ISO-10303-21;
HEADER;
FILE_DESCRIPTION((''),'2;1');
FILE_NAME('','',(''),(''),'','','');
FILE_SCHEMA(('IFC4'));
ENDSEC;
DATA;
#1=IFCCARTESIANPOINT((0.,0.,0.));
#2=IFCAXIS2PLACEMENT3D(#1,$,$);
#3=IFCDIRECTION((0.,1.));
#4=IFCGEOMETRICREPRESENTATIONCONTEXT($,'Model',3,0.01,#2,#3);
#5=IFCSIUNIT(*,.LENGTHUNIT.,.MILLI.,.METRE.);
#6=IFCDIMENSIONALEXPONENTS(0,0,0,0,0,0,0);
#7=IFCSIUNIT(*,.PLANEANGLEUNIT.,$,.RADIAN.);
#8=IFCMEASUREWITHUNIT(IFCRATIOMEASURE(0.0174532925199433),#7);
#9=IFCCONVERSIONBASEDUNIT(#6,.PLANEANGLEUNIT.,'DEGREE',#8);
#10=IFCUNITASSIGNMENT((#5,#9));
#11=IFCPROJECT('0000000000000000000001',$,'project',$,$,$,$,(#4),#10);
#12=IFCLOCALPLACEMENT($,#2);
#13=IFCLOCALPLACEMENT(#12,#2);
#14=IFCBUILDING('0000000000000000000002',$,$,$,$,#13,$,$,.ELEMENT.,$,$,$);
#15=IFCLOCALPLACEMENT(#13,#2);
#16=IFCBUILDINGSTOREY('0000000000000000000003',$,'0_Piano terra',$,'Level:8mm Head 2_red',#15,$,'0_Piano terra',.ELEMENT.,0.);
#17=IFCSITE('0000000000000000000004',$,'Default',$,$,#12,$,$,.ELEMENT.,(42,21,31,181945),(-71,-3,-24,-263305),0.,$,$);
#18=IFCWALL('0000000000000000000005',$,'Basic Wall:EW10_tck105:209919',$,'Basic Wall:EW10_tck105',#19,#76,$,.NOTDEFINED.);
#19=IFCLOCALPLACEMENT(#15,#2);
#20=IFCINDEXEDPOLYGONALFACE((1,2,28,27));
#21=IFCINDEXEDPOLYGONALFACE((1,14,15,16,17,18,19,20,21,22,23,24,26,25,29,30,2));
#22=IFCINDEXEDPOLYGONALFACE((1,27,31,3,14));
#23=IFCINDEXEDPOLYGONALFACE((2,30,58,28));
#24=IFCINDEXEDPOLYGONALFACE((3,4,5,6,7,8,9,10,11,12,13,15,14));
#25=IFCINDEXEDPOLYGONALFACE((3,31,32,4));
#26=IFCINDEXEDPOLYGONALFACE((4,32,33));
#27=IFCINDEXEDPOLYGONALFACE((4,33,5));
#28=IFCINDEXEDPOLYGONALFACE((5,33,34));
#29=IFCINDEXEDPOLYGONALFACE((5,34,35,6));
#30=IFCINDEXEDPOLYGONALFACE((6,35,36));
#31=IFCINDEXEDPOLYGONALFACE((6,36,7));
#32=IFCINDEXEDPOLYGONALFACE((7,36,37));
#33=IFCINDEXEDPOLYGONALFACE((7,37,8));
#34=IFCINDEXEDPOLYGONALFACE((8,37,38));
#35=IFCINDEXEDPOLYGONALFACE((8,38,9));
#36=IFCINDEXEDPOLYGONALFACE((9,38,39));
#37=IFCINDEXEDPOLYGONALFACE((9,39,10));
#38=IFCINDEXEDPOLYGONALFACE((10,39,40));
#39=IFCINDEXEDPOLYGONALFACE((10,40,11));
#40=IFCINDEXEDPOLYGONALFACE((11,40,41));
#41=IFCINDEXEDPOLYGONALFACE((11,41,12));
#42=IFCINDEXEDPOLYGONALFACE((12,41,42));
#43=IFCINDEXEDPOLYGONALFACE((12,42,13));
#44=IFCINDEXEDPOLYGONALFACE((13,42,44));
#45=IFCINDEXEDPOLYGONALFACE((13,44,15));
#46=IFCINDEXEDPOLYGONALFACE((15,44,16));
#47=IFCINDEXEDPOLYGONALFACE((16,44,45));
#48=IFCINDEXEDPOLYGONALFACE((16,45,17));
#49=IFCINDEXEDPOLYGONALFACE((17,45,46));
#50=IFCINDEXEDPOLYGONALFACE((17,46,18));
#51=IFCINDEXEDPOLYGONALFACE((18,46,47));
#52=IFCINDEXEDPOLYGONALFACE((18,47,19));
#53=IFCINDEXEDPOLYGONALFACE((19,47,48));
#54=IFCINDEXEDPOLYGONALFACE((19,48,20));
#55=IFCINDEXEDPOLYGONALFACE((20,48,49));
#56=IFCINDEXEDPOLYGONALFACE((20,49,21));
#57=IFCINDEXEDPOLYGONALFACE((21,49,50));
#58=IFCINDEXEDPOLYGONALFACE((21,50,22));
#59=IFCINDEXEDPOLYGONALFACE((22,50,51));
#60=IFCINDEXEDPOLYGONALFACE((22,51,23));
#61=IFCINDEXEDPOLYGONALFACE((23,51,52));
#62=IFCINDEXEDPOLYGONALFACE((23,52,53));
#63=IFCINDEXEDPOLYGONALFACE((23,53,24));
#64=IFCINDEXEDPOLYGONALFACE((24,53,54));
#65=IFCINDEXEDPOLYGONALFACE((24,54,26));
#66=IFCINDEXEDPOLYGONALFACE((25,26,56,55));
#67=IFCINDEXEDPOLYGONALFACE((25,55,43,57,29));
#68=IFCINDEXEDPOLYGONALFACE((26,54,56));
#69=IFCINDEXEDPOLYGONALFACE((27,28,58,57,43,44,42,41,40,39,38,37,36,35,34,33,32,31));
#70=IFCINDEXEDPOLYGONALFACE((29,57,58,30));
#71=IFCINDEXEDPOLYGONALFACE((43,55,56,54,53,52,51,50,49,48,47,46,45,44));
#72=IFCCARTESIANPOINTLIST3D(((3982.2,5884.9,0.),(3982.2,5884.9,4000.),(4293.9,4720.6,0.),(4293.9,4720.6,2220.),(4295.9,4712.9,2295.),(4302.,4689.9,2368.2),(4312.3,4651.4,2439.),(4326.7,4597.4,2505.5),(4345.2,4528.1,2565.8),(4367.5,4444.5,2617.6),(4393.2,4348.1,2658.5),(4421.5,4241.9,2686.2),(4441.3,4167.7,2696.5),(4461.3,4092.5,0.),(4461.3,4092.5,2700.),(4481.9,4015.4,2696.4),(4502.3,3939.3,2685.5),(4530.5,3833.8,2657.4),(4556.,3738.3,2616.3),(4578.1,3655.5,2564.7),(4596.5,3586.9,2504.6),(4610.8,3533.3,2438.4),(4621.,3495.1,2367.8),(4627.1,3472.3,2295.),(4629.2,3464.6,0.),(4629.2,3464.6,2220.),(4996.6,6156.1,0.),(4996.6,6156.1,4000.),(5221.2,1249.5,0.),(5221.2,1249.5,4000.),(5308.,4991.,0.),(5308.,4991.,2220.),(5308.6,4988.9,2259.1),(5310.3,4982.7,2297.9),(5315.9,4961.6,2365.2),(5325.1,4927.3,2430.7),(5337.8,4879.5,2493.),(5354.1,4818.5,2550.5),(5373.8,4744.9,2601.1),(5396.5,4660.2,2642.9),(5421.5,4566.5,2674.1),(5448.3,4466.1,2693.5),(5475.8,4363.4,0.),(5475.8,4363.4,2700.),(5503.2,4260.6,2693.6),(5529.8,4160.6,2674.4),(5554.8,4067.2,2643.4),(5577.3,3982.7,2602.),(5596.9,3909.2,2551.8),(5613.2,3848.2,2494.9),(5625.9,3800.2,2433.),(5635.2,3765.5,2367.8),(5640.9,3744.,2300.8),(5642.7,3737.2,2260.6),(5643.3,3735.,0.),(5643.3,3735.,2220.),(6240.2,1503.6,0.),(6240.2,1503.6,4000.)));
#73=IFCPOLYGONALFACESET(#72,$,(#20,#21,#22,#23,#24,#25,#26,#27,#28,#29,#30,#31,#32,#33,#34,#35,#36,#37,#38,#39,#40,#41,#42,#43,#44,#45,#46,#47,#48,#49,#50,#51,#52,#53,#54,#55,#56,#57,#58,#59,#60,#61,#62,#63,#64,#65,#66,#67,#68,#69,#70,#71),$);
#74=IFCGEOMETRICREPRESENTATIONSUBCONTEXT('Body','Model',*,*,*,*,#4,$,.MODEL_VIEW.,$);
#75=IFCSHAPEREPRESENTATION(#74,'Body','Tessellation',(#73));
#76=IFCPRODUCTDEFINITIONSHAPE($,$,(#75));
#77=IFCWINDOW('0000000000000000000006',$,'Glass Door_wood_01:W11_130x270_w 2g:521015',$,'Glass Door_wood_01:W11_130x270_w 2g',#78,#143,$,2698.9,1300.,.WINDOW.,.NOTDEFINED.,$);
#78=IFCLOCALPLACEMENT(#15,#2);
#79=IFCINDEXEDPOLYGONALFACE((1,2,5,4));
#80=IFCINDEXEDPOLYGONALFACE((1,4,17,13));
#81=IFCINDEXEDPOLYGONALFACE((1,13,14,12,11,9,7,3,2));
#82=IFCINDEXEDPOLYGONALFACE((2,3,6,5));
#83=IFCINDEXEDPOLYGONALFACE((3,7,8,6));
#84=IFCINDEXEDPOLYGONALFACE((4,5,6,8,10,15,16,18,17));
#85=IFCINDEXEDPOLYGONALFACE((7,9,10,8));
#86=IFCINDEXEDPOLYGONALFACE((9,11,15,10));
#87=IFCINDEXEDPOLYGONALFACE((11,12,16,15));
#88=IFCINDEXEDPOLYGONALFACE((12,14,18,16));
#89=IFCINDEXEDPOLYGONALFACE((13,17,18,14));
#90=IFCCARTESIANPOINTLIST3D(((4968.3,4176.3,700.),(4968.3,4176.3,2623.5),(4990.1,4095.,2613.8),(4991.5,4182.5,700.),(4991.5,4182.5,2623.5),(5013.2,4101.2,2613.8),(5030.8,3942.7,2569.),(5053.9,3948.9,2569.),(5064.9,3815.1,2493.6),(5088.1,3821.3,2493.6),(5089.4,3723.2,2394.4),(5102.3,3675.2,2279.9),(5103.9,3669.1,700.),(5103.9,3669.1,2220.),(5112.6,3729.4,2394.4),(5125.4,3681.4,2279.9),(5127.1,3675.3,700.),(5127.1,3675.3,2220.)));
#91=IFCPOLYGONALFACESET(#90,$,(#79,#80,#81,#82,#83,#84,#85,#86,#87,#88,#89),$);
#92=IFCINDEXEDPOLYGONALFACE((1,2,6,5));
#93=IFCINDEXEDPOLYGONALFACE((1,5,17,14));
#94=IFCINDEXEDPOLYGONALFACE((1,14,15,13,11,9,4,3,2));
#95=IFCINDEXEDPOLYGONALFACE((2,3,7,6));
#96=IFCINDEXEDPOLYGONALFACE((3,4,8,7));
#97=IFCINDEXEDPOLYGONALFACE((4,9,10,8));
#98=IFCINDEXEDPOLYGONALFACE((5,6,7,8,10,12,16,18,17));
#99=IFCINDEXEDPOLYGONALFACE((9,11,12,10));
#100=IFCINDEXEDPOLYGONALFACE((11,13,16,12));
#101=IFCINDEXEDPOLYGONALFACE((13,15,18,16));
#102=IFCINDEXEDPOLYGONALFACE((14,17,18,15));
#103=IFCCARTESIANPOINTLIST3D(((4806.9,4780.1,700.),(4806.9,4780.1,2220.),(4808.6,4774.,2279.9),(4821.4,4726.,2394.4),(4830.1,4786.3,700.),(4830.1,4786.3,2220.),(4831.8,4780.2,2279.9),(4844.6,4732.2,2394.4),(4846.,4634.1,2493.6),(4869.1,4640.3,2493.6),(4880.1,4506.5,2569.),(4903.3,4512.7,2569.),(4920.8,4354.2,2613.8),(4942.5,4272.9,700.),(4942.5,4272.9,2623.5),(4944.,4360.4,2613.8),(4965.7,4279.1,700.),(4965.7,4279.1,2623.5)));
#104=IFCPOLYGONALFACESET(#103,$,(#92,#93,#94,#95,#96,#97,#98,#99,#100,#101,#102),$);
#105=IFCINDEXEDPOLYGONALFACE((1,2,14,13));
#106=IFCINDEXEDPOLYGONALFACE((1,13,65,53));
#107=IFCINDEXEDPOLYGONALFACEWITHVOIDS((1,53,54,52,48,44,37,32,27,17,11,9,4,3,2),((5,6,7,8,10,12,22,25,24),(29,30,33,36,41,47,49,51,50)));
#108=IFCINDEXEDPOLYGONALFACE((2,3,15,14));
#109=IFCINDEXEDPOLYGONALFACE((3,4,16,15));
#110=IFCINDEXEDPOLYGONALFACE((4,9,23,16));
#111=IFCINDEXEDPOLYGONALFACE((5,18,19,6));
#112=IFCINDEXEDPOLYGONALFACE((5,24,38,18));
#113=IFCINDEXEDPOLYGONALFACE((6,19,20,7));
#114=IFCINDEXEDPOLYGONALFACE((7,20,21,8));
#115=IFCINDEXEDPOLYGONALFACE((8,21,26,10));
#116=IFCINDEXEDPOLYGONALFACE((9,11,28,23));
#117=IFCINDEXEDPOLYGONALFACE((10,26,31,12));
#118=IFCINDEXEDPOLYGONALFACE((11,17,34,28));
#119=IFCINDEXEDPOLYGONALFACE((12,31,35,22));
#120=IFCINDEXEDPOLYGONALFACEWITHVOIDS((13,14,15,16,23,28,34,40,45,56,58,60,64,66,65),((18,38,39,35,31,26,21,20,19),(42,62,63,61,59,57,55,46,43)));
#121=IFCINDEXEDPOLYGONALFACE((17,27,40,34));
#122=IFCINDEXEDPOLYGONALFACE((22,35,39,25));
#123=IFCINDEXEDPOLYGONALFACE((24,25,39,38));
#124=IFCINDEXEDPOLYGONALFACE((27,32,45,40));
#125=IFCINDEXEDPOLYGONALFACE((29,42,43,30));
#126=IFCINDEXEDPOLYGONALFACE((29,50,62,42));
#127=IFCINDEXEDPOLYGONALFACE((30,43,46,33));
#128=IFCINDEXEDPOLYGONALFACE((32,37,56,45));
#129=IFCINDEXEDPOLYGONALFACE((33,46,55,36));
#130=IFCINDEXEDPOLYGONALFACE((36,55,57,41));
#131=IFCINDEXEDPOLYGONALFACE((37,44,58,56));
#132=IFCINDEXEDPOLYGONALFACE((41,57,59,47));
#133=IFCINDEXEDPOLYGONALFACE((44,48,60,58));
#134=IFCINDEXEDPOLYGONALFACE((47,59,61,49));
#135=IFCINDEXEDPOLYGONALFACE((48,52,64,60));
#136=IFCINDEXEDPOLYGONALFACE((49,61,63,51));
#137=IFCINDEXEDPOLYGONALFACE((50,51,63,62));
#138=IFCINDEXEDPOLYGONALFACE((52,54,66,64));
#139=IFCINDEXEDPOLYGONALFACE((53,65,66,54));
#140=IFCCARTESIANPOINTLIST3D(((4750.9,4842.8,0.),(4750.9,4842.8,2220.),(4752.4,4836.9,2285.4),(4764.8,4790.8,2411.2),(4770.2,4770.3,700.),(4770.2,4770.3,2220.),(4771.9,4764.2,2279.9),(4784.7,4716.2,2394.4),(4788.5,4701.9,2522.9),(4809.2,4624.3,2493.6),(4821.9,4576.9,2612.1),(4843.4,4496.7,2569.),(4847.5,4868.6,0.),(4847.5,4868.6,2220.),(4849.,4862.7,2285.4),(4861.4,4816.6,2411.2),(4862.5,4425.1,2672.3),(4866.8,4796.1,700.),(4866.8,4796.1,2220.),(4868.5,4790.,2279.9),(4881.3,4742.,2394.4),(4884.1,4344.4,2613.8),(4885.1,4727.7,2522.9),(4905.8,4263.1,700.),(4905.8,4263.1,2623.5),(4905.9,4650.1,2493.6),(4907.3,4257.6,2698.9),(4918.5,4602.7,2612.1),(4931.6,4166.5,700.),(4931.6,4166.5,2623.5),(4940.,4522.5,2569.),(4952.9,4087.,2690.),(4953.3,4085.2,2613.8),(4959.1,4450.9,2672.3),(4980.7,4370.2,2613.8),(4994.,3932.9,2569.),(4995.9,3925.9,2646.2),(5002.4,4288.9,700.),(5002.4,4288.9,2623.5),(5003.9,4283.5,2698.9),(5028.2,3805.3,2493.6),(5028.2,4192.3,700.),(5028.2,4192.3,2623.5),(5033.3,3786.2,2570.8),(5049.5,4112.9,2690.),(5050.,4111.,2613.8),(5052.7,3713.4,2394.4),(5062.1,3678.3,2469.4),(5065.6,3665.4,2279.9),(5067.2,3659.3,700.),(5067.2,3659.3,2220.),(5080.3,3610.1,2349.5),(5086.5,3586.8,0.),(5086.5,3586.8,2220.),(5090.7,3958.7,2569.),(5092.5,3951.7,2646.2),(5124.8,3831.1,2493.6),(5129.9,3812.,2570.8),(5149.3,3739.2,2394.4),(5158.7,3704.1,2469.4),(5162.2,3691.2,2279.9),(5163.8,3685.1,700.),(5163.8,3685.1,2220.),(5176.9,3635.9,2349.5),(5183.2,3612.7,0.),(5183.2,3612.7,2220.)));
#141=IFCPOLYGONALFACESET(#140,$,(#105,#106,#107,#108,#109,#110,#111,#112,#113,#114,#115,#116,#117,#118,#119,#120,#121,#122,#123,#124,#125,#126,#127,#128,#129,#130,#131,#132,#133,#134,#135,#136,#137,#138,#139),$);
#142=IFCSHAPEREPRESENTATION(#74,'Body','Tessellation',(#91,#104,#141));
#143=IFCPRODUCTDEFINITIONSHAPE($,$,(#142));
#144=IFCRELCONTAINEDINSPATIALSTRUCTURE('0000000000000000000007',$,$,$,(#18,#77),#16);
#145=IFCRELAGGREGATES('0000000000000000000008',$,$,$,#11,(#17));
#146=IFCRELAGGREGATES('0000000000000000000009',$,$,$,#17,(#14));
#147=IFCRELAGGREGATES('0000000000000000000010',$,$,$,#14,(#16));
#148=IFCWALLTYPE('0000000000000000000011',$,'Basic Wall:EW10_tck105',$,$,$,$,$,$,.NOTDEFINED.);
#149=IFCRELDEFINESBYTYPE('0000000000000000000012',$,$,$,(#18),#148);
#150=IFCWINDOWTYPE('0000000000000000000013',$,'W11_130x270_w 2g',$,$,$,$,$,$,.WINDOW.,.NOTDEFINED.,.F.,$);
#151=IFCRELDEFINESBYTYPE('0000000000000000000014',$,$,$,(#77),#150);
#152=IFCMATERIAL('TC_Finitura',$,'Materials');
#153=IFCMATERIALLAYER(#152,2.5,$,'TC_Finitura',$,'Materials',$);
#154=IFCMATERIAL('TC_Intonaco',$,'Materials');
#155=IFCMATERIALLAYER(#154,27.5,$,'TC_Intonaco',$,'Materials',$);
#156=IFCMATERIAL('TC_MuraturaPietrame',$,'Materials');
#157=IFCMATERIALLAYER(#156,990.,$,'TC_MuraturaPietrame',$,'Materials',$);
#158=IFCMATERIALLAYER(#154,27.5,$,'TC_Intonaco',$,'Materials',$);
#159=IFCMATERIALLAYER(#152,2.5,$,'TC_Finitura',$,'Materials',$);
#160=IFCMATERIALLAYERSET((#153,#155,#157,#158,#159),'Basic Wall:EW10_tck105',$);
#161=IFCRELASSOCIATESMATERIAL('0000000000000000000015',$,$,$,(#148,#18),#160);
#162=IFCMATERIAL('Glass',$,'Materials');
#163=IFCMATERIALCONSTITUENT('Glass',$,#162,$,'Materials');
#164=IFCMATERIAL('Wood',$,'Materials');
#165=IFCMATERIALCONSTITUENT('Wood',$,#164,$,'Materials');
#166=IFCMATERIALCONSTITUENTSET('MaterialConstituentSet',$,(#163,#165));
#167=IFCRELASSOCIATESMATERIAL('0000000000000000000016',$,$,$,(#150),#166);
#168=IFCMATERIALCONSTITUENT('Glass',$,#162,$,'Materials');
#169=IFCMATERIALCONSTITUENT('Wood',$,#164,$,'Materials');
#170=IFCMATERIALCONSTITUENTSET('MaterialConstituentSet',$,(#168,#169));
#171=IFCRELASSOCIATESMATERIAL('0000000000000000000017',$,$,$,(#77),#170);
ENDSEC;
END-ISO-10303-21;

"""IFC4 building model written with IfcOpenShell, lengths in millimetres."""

from ifc_helpers import new_model, entity, si_unit, converted_unit, direction, frame, frame_2d, origin, place, context, subcontext, project, spatial, polyline, ellipse_curve, parameter, trimmed, segment, composite_curve, outline, extrude, clip, bounded_halfspace, source, transform, mapped, material, layer, layer_set, layer_usage, constituent, constituent_set, type_object, type_shapes, element, fill, save


model = new_model("IFC4")

# Units and contexts
model_context = context("Model", 3, precision=0.01, world=origin(), true_north=direction((0.0, 1.0)))
body_context = subcontext(model_context, "Body", "Model", "MODEL_VIEW")
ifc_project = project(units=[si_unit("LENGTHUNIT", "METRE", prefix="MILLI"), converted_unit("PLANEANGLEUNIT", "DEGREE", entity("IfcRatioMeasure", 0.0174532925199433), si_unit("PLANEANGLEUNIT", "RADIAN"), dimensions=[0, 0, 0, 0, 0, 0, 0])], contexts=[model_context])

# Site, building, storey
site_placement = place(None, origin())
site = spatial("IfcSite", under=ifc_project, at=site_placement, Name="Default", CompositionType="ELEMENT", RefLatitude=(42, 21, 31, 181945), RefLongitude=(-71, -3, -24, -263305), RefElevation=0.0)
building_placement = place(site_placement, origin())
building = spatial("IfcBuilding", under=site, at=building_placement, CompositionType="ELEMENT")
storey_placement = place(building_placement, origin())
storey = spatial("IfcBuildingStorey", under=building, at=storey_placement, Name="0_Piano terra", ObjectType="Level:8mm Head 2_red", LongName="0_Piano terra", CompositionType="ELEMENT", Elevation=0.0)

# Shared definitions
ifc_material_1 = material(Name="TC_Finitura", Category="Materials")
ifc_material_2 = material(Name="TC_Intonaco", Category="Materials")
ifc_material_3 = material(Name="TC_MuraturaPietrame", Category="Materials")
ifc_material_4 = material(Name="Glass", Category="Materials")
ifc_material_5 = material(Name="Wood", Category="Materials")

# Wall, opening, window
ifc_layer_1 = layer(ifc_material_1, 2.5, Name="TC_Finitura", Category="Materials")
ifc_layer_2 = layer(ifc_material_2, 27.5, Name="TC_Intonaco", Category="Materials")
ifc_layer_3 = layer(ifc_material_3, 990.0, Name="TC_MuraturaPietrame", Category="Materials")
ifc_layer_4 = layer(ifc_material_2, 27.5, Name="TC_Intonaco", Category="Materials")
ifc_layer_5 = layer(ifc_material_1, 2.5, Name="TC_Finitura", Category="Materials")
ifc_layer_set_1 = layer_set([ifc_layer_1, ifc_layer_2, ifc_layer_3, ifc_layer_4, ifc_layer_5], Name="Basic Wall:EW10_tck105")
ifc_layer_usage_1 = layer_usage(ifc_layer_set_1, "AXIS2", "NEGATIVE", 525.0)
wall_type_1 = type_object("IfcWallType", Name="Basic Wall:EW10_tck105", PredefinedType="NOTDEFINED", material=ifc_layer_set_1)
wall_1_placement = place(storey_placement, frame((4489.4, 6020.5, 0.0), z_axis=(0.0, 0.0, 1.0), x_axis=(0.25822, -0.966086, 0.0)))
wall_1 = element("IfcWall", 1, at=wall_1_placement, inside=storey, type_object=wall_type_1, material=ifc_layer_usage_1, Name="Basic Wall:EW10_tck105:209919", ObjectType="Basic Wall:EW10_tck105", PredefinedType="NOTDEFINED", context=body_context, shape_type="Clipping", body=[
    clip(extrude(outline(polyline([(0.0, -525.0), (4798.1, -525.0), (4815.8, 525.0), (3815.7, 525.0), (415.3, 525.0), (0.0, 525.0), (0.0, -525.0)])), origin(), (0.0, 0.0, 1.0), 4000.0), bounded_halfspace(frame((0.0, -525.0, 4000.0), z_axis=(0.0, 0.0, -1.0), x_axis=(0.999848, 0.017444, 0.0)), True, frame((0.0, -525.0, 4000.0)), polyline([(0.0, 0.0), (4798.1, 0.0), (4815.8, 1050.0), (3815.7, 1050.0), (415.3, 1050.0), (0.0, 1050.0), (0.0, 0.0)]))),
])
opening_1_placement = place(wall_1_placement, frame((1205.3, -524.6, 0.0)))
opening_1 = element("IfcOpeningElement", 2, at=opening_1_placement, cuts=wall_1, ObjectType="Opening", PredefinedType="OPENING", context=body_context, shape_type="SweptSolid", body=[
    extrude(outline(composite_curve([segment(polyline([(0.0, 0.0), (2220.0, 0.0)]), True, "CONTINUOUS"), segment(trimmed(ellipse_curve(frame_2d((2220.0, 650.0), x_axis=(0.0, -1.0)), 650.0, 480.0), [parameter(0.0)], [parameter(180.0)], True, "PARAMETER"), True, "CONTINUOUS"), segment(polyline([(2220.0, 1300.0), (0.0, 1300.0)]), True, "CONTINUOUS"), segment(polyline([(0.0, 1300.0), (0.0, 0.0)]), True, "CONTINUOUS")], self_intersect=False)), frame((0.0, 0.0, 0.0), z_axis=(0.00062, 1.0, 0.0), x_axis=(0.0, 0.0, 1.0)), (0.0, 0.0, 1.0), 1050.0),
])
ifc_constituent_1 = constituent(ifc_material_4, Name="Glass", Category="Materials")
ifc_constituent_2 = constituent(ifc_material_5, Name="Wood", Category="Materials")
ifc_constituent_set_1 = constituent_set(constituents=[ifc_constituent_1, ifc_constituent_2], Name="MaterialConstituentSet")
ifc_constituent_3 = constituent(ifc_material_4, Name="Glass", Category="Materials")
ifc_constituent_4 = constituent(ifc_material_5, Name="Wood", Category="Materials")
ifc_constituent_set_2 = constituent_set(constituents=[ifc_constituent_3, ifc_constituent_4], Name="MaterialConstituentSet")
window_type_1 = type_object("IfcWindowType", Name="W11_130x270_w 2g", ParameterTakesPrecedence=False, PartitioningType="NOTDEFINED", PredefinedType="WINDOW", material=ifc_constituent_set_2)
shared_shape_1 = source(origin(), body_context, "Body", "SweptSolid", [
    extrude(outline(polyline([(-304.2, -1366.0), (220.8, -1366.0), (220.8, 154.0), (214.5, 213.9), (164.8, 328.4), (69.7, 427.6), (-62.4, 503.0), (-220.0, 547.8), (-304.2, 557.4), (-304.2, -1366.0)])), frame((295.8, 513.0, 2066.0), z_axis=(0.0, 1.0, 0.0), x_axis=(-1.0, 0.0, 0.0)), (0.0, 0.0, 1.0), 24.0),
    extrude(outline(polyline([(-1366.0, -304.2), (557.4, -304.2), (547.8, -220.0), (503.0, -62.4), (427.6, 69.7), (328.4, 164.8), (213.9, 214.5), (154.0, 220.8), (-1366.0, 220.8), (-1366.0, -304.2)])), frame((1004.2, 513.0, 2066.0), z_axis=(0.0, 1.0, 0.0), x_axis=(0.0, 0.0, 1.0)), (0.0, 0.0, 1.0), 24.0),
    extrude(outline(polyline([(-628.3, -2157.9), (671.7, -2157.9), (671.7, 62.1), (647.6, 191.6), (577.0, 311.5), (465.3, 412.9), (320.7, 488.3), (153.9, 532.0), (-22.7, 541.0), (-196.0, 514.4), (-353.2, 454.2), (-482.5, 365.0), (-574.5, 253.3), (-622.3, 127.4), (-628.3, 62.1), (-628.3, -2157.9)]), holes=[polyline([(-28.3, -1457.9), (-553.3, -1457.9), (-553.3, 62.1), (-547.0, 122.0), (-497.3, 236.5), (-402.2, 335.7), (-270.1, 411.1), (-112.5, 455.9), (-28.3, 465.6), (-28.3, -1457.9)]), polyline([(71.7, -1457.9), (71.7, 465.6), (155.8, 455.9), (313.4, 411.1), (445.6, 335.7), (540.6, 236.5), (590.3, 122.0), (596.7, 62.1), (596.7, -1457.9), (71.7, -1457.9)])]), frame((671.7, 475.0, 2157.9), z_axis=(0.0, 1.0, 0.0), x_axis=(-1.0, 0.0, 0.0)), (0.0, 0.0, 1.0), 100.0),
])
type_shapes(window_type_1, [shared_shape_1])
window_1_placement = place(opening_1_placement, frame((1300.0, 1048.0, 0.0), z_axis=(0.0, 0.0, 1.0), x_axis=(-1.0, 0.0, 0.0)))
window_1 = element("IfcWindow", 3, at=window_1_placement, inside=storey, type_object=window_type_1, material=ifc_constituent_set_1, Name="Glass Door_wood_01:W11_130x270_w 2g:521015", ObjectType="Glass Door_wood_01:W11_130x270_w 2g", OverallHeight=2698.9, OverallWidth=1300.0, PartitioningType="NOTDEFINED", PredefinedType="WINDOW", context=body_context, shape_type="MappedRepresentation", body=[
    mapped(shared_shape_1, transform((0.0, 0.0, 0.0), scale=1.0)),
])
fill(opening_1, window_1)

save(model, "model.ifc")
